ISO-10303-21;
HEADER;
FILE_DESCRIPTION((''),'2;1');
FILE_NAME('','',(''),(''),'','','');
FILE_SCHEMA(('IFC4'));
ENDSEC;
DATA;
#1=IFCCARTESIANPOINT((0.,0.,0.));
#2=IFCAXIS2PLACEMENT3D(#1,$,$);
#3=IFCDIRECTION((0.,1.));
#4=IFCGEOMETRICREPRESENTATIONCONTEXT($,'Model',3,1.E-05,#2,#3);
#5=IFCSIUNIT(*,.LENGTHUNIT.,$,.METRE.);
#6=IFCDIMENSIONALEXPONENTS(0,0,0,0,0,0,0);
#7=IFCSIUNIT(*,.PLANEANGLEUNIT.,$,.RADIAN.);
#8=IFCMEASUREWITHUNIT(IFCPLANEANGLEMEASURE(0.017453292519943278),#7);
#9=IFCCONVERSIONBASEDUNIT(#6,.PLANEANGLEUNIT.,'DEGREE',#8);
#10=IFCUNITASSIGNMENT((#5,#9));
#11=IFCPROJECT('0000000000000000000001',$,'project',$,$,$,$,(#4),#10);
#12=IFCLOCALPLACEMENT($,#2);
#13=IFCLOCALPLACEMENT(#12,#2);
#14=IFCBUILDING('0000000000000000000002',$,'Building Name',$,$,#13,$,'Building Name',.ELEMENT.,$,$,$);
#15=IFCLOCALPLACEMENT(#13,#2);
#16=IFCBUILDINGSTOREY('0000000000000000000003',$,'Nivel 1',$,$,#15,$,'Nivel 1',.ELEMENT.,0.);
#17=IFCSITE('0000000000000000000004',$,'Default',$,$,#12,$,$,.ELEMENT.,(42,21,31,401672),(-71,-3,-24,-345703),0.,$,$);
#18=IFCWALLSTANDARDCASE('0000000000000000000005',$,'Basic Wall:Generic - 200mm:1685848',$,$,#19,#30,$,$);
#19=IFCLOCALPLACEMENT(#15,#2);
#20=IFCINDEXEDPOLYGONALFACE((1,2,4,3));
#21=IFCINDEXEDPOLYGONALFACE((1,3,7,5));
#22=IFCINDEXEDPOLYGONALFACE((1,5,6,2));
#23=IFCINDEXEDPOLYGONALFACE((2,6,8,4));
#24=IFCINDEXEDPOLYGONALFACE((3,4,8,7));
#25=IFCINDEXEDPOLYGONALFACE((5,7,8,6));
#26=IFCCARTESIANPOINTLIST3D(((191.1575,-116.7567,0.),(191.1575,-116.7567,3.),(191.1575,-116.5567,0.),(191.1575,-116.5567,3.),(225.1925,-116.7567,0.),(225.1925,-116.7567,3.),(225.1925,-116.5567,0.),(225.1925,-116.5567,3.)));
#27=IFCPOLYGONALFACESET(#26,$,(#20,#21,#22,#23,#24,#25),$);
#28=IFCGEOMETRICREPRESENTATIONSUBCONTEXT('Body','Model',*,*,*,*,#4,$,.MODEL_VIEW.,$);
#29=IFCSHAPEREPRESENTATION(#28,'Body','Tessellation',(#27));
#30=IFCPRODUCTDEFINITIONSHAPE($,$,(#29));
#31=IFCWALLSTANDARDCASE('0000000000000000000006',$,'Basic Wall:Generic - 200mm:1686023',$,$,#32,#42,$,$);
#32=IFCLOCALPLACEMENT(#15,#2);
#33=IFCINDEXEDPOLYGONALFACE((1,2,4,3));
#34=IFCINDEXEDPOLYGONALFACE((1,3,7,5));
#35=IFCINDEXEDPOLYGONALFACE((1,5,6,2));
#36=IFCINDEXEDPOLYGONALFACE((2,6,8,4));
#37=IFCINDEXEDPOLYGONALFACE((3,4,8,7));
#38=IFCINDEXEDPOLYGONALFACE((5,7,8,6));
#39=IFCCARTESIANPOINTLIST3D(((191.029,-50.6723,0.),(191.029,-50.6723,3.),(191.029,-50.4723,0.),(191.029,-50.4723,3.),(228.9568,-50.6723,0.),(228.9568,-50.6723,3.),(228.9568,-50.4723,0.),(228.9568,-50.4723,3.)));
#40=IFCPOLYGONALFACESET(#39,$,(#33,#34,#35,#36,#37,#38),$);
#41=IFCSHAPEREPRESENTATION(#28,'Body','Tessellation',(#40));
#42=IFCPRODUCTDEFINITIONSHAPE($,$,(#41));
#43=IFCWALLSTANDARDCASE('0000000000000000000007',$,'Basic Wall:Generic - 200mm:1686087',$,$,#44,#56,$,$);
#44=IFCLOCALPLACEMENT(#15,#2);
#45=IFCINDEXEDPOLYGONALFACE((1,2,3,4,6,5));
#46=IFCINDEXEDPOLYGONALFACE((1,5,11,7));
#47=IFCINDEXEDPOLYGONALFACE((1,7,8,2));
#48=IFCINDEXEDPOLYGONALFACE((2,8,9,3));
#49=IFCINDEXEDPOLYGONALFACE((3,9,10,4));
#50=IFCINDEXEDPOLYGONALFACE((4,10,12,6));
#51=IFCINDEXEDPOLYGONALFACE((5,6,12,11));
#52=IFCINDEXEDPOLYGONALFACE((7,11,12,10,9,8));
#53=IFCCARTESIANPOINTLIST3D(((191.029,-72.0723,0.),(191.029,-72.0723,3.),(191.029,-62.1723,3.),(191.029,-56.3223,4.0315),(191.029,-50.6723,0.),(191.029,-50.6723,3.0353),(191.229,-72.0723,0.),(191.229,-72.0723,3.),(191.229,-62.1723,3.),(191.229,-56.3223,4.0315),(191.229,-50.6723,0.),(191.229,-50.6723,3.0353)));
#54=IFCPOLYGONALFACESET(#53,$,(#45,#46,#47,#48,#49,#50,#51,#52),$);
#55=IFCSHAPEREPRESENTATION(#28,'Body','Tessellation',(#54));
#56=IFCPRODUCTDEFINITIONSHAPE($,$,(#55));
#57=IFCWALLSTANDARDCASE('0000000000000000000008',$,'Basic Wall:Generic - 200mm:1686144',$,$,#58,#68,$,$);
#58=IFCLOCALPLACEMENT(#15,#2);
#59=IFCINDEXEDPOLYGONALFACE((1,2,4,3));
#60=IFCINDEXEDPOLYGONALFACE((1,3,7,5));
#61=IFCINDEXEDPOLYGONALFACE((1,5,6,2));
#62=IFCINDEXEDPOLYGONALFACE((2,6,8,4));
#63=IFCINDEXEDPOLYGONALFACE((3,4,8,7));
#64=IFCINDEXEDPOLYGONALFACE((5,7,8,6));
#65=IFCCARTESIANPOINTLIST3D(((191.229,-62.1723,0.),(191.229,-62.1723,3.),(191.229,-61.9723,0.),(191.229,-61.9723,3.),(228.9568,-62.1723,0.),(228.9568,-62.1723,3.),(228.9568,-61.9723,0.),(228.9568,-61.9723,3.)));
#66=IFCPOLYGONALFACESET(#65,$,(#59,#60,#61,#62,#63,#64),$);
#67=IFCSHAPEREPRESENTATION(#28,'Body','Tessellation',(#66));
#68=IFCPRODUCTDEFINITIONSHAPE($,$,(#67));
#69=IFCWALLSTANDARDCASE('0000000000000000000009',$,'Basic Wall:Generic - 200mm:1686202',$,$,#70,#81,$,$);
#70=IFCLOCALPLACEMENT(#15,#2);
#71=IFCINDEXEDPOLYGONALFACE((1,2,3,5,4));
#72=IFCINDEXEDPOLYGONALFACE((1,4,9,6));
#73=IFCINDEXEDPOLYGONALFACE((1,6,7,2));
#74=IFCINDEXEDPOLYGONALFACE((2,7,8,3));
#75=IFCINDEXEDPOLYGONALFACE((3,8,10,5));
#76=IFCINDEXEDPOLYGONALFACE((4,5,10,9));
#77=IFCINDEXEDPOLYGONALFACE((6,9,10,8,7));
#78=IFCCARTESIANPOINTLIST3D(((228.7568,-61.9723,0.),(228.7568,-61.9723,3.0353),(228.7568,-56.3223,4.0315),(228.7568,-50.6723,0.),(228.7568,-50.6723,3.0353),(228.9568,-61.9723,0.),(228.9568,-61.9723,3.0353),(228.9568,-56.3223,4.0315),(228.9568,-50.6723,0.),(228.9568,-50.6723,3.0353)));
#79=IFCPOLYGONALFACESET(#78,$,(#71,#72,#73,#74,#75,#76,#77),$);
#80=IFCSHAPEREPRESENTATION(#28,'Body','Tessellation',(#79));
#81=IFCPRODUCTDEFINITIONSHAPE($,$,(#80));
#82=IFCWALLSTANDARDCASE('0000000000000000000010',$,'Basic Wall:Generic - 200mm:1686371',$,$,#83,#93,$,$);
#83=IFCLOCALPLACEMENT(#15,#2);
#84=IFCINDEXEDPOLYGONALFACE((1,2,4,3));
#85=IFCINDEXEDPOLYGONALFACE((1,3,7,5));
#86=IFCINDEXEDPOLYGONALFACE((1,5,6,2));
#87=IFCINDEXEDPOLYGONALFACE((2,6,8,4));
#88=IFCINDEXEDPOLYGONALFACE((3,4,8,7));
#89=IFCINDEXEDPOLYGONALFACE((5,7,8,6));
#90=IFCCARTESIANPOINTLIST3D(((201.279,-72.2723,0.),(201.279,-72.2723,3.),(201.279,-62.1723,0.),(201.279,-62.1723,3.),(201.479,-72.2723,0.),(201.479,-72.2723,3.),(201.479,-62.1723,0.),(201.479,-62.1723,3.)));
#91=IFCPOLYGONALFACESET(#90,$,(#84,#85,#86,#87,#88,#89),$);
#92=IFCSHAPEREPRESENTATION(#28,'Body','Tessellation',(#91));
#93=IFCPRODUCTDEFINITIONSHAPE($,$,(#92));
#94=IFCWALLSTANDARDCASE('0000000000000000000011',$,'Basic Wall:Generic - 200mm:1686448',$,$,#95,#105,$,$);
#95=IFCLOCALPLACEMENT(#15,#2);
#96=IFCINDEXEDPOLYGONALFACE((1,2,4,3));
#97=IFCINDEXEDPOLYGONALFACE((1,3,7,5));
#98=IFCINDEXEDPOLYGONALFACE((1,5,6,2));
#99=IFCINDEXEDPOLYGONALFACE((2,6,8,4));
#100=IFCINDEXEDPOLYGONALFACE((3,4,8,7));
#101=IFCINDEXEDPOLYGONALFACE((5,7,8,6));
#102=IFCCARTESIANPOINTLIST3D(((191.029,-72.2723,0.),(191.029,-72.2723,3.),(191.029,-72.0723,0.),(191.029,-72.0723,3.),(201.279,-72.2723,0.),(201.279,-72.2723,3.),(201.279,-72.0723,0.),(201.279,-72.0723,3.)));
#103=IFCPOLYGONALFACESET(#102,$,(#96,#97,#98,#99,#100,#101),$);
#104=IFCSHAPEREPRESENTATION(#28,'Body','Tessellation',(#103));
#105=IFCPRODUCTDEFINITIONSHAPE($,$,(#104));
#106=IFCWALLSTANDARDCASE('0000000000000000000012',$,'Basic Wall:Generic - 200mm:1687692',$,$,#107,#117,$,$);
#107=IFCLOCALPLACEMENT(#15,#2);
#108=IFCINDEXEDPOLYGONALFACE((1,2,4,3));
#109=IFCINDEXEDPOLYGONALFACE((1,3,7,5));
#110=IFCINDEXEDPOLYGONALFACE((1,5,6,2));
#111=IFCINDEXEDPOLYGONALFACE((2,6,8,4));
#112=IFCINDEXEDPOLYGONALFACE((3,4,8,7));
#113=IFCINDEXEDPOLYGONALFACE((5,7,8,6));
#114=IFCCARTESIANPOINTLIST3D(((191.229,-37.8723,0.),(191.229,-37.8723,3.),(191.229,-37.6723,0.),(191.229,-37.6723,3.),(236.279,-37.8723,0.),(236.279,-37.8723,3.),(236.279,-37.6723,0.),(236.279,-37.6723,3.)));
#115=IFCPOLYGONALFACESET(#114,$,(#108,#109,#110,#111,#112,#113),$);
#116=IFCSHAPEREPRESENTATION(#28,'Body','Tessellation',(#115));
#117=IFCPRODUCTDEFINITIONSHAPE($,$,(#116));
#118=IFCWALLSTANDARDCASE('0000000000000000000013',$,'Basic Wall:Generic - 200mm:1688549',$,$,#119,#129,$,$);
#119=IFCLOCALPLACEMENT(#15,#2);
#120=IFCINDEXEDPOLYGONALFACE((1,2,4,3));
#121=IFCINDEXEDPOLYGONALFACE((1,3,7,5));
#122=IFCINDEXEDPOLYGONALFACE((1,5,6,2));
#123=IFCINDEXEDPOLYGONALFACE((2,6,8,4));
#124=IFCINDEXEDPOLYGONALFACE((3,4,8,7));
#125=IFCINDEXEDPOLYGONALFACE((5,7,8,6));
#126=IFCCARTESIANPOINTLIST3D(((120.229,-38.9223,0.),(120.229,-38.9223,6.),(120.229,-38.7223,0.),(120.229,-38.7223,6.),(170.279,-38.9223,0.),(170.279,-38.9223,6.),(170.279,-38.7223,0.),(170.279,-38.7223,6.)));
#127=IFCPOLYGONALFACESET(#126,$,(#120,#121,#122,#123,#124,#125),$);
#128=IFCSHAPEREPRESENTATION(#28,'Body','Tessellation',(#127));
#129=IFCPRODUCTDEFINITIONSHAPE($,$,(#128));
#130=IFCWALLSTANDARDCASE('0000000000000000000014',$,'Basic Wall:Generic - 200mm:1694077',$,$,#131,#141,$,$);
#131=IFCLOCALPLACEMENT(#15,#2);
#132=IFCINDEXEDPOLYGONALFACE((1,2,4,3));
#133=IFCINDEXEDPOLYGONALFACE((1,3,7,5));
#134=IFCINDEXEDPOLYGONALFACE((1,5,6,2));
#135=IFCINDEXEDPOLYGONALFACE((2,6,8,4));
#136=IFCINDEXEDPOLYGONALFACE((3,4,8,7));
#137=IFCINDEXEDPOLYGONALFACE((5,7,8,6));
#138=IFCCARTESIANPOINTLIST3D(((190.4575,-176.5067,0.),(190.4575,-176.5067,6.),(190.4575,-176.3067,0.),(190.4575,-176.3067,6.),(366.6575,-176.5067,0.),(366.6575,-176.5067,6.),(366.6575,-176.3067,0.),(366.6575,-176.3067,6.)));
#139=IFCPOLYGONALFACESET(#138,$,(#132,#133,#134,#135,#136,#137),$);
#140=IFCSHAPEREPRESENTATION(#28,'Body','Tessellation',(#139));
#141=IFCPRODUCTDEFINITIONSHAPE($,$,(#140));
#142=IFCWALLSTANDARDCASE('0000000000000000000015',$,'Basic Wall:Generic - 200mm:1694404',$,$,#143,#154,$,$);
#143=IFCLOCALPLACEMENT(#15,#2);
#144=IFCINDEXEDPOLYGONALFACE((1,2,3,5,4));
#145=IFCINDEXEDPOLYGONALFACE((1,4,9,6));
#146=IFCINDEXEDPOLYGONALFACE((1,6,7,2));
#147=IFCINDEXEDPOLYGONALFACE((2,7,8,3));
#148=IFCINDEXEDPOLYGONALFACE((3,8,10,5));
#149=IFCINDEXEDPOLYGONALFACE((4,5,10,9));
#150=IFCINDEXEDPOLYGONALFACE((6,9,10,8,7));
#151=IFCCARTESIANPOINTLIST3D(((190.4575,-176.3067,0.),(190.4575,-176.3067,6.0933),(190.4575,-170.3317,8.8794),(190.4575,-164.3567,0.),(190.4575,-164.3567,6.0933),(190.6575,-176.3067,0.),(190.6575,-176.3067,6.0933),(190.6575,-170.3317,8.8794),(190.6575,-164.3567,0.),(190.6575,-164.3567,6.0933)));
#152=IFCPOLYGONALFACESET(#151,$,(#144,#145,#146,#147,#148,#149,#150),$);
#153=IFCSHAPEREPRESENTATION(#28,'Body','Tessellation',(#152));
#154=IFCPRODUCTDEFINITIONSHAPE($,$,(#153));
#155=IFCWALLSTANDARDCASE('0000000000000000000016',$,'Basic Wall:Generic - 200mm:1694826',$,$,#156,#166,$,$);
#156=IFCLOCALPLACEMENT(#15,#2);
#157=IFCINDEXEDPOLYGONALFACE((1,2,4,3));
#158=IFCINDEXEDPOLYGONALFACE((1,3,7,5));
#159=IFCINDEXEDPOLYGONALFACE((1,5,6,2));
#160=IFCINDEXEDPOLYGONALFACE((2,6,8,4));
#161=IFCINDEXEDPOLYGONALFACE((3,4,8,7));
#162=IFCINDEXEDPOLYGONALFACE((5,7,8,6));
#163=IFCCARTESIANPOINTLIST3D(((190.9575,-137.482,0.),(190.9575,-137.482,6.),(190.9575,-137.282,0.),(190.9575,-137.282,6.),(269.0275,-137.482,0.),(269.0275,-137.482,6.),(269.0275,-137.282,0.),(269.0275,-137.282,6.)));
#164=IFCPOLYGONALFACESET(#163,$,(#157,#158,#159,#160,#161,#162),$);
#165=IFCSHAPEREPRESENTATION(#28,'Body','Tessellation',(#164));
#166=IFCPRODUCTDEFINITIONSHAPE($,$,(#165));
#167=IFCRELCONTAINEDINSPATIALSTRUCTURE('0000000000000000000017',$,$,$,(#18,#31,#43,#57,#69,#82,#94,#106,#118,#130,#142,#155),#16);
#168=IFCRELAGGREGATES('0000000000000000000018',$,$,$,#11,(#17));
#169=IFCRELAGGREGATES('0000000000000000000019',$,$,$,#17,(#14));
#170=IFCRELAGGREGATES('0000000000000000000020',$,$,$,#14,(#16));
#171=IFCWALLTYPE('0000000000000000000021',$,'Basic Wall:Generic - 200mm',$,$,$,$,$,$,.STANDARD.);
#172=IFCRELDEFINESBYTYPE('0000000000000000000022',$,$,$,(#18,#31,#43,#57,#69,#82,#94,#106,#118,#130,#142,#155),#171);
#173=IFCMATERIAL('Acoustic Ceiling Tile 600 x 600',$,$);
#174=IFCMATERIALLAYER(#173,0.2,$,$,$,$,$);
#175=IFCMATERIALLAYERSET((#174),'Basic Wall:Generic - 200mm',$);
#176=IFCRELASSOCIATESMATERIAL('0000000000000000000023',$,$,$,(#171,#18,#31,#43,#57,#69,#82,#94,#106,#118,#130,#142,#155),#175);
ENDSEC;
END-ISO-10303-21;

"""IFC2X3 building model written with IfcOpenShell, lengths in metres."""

from ifc_helpers import new_model, entity, si_unit, converted_unit, direction, frame, frame_2d, origin, place, context, subcontext, project, spatial, polyline, rectangle, extrude, clip, bounded_halfspace, material, layer, layer_set, layer_usage, type_object, element, save


model = new_model("IFC2X3")

# Units and contexts
model_context = context("Model", 3, precision=1e-05, world=origin(), true_north=direction((0.0, 1.0)))
body_context = subcontext(model_context, "Body", "Model", "MODEL_VIEW")
ifc_project = project(units=[si_unit("LENGTHUNIT", "METRE"), converted_unit("PLANEANGLEUNIT", "DEGREE", entity("IfcPlaneAngleMeasure", 0.017453292519943278), si_unit("PLANEANGLEUNIT", "RADIAN"), dimensions=[0, 0, 0, 0, 0, 0, 0])], contexts=[model_context])

# Site, building, storey
site_placement = place(None, origin())
site = spatial("IfcSite", under=ifc_project, at=site_placement, Name="Default", CompositionType="ELEMENT", RefLatitude=(42, 21, 31, 401672), RefLongitude=(-71, -3, -24, -345703), RefElevation=0.0)
building_placement = place(site_placement, origin())
building = spatial("IfcBuilding", under=site, at=building_placement, Name="Building Name", LongName="Building Name", CompositionType="ELEMENT")
storey_placement = place(building_placement, origin())
storey = spatial("IfcBuildingStorey", under=building, at=storey_placement, Name="Nivel 1", LongName="Nivel 1", CompositionType="ELEMENT", Elevation=0.0)

# Walls
ifc_material_1 = material(Name="Acoustic Ceiling Tile 600 x 600")
ifc_layer = layer(ifc_material_1, 0.2)
ifc_layer_set = layer_set([ifc_layer], Name="Basic Wall:Generic - 200mm")
wall_type_1 = type_object("IfcWallType", Name="Basic Wall:Generic - 200mm", PredefinedType="STANDARD", material=ifc_layer_set)
ifc_layer_usage_1 = layer_usage(ifc_layer_set, "AXIS2", "NEGATIVE", 0.1)
wall_1_placement = place(storey_placement, frame((191.1575, -116.6567, 0.0)))
element("IfcWallStandardCase", 1, at=wall_1_placement, inside=storey, type_object=wall_type_1, material=ifc_layer_usage_1, Name="Basic Wall:Generic - 200mm:1685848", context=body_context, shape_type="SweptSolid", body=[
    extrude(rectangle(XDim=34.035, YDim=0.2, at=frame_2d((17.0175, 0.0), x_axis=(-1.0, 0.0))), origin(), (0.0, 0.0, 1.0), 3.0),
])
ifc_layer_usage_2 = layer_usage(ifc_layer_set, "AXIS2", "NEGATIVE", 0.1)
wall_2_placement = place(storey_placement, frame((228.9568, -50.5723, 0.0), z_axis=(0.0, 0.0, 1.0), x_axis=(-1.0, 0.0, 0.0)))
element("IfcWallStandardCase", 2, at=wall_2_placement, inside=storey, type_object=wall_type_1, material=ifc_layer_usage_2, Name="Basic Wall:Generic - 200mm:1686023", context=body_context, shape_type="SweptSolid", body=[
    extrude(rectangle(XDim=37.9278, YDim=0.2, at=frame_2d((18.9639, 0.0), x_axis=(-1.0, 0.0))), origin(), (0.0, 0.0, 1.0), 3.0),
])
ifc_layer_usage_3 = layer_usage(ifc_layer_set, "AXIS2", "NEGATIVE", 0.1)
wall_3_placement = place(storey_placement, frame((191.129, -50.6723, 0.0), z_axis=(0.0, 0.0, 1.0), x_axis=(0.0, -1.0, 0.0)))
element("IfcWallStandardCase", 3, at=wall_3_placement, inside=storey, type_object=wall_type_1, material=ifc_layer_usage_3, Name="Basic Wall:Generic - 200mm:1686087", context=body_context, shape_type="Clipping", body=[
    clip(clip(clip(extrude(rectangle(XDim=21.4, YDim=0.2, at=frame_2d((10.7, 0.0), x_axis=(-1.0, 0.0))), origin(), (0.0, 0.0, 1.0), 4.0315), bounded_halfspace(frame((0.0, -0.1, 3.0353), z_axis=(-0.173648, 0.0, 0.984808), x_axis=(0.0, -1.0, 0.0)), False, frame((0.0, -0.1, 3.0353)), polyline([(0.0, 0.0), (5.65, 0.0), (5.65, 0.2), (0.0, 0.2), (0.0, 0.0)]))), bounded_halfspace(frame((5.65, -0.1, 4.0315), z_axis=(0.173648, 0.0, 0.984808), x_axis=(0.0, 1.0, 0.0)), False, frame((5.65, -0.1, 4.0315)), polyline([(0.0, 0.0), (5.85, 0.0), (5.85, 0.2), (0.0, 0.2), (0.0, 0.0)]))), bounded_halfspace(frame((11.5, -0.1, 3.0), z_axis=(0.0, 0.0, 1.0), x_axis=(0.0, 1.0, 0.0)), False, frame((11.5, -0.1, 3.0)), polyline([(0.0, 0.0), (9.9, 0.0), (9.9, 0.2), (0.0, 0.2), (0.0, 0.0)]))),
])
ifc_layer_usage_4 = layer_usage(ifc_layer_set, "AXIS2", "NEGATIVE", 0.1)
wall_4_placement = place(storey_placement, frame((191.229, -62.0723, 0.0)))
element("IfcWallStandardCase", 4, at=wall_4_placement, inside=storey, type_object=wall_type_1, material=ifc_layer_usage_4, Name="Basic Wall:Generic - 200mm:1686144", context=body_context, shape_type="SweptSolid", body=[
    extrude(rectangle(XDim=37.7278, YDim=0.2, at=frame_2d((18.8639, 0.0), x_axis=(-1.0, 0.0))), origin(), (0.0, 0.0, 1.0), 3.0),
])
ifc_layer_usage_5 = layer_usage(ifc_layer_set, "AXIS2", "NEGATIVE", 0.1)
wall_5_placement = place(storey_placement, frame((228.8568, -61.9723, 0.0), z_axis=(0.0, 0.0, 1.0), x_axis=(0.0, 1.0, 0.0)))
element("IfcWallStandardCase", 5, at=wall_5_placement, inside=storey, type_object=wall_type_1, material=ifc_layer_usage_5, Name="Basic Wall:Generic - 200mm:1686202", context=body_context, shape_type="Clipping", body=[
    clip(clip(extrude(rectangle(XDim=11.3, YDim=0.2, at=frame_2d((5.65, 0.0), x_axis=(-1.0, 0.0))), origin(), (0.0, 0.0, 1.0), 4.0315), bounded_halfspace(frame((5.65, -0.1, 4.0315), z_axis=(0.173648, 0.0, 0.984808), x_axis=(0.0, 1.0, 0.0)), False, frame((5.65, -0.1, 4.0315)), polyline([(0.0, 0.0), (5.65, 0.0), (5.65, 0.2), (0.0, 0.2), (0.0, 0.0)]))), bounded_halfspace(frame((0.0, -0.1, 3.0353), z_axis=(-0.173648, 0.0, 0.984808), x_axis=(0.0, -1.0, 0.0)), False, frame((0.0, -0.1, 3.0353)), polyline([(0.0, 0.0), (5.65, 0.0), (5.65, 0.2), (0.0, 0.2), (0.0, 0.0)]))),
])
ifc_layer_usage_6 = layer_usage(ifc_layer_set, "AXIS2", "NEGATIVE", 0.1)
wall_6_placement = place(storey_placement, frame((201.379, -62.1723, 0.0), z_axis=(0.0, 0.0, 1.0), x_axis=(0.0, -1.0, 0.0)))
element("IfcWallStandardCase", 6, at=wall_6_placement, inside=storey, type_object=wall_type_1, material=ifc_layer_usage_6, Name="Basic Wall:Generic - 200mm:1686371", context=body_context, shape_type="SweptSolid", body=[
    extrude(rectangle(XDim=10.1, YDim=0.2, at=frame_2d((5.05, 0.0), x_axis=(-1.0, 0.0))), origin(), (0.0, 0.0, 1.0), 3.0),
])
ifc_layer_usage_7 = layer_usage(ifc_layer_set, "AXIS2", "NEGATIVE", 0.1)
wall_7_placement = place(storey_placement, frame((201.279, -72.1723, 0.0), z_axis=(0.0, 0.0, 1.0), x_axis=(-1.0, 0.0, 0.0)))
element("IfcWallStandardCase", 7, at=wall_7_placement, inside=storey, type_object=wall_type_1, material=ifc_layer_usage_7, Name="Basic Wall:Generic - 200mm:1686448", context=body_context, shape_type="SweptSolid", body=[
    extrude(rectangle(XDim=10.25, YDim=0.2, at=frame_2d((5.125, 0.0), x_axis=(-1.0, 0.0))), origin(), (0.0, 0.0, 1.0), 3.0),
])
ifc_layer_usage_8 = layer_usage(ifc_layer_set, "AXIS2", "NEGATIVE", 0.1)
wall_8_placement = place(storey_placement, frame((191.229, -37.7723, 0.0)))
element("IfcWallStandardCase", 8, at=wall_8_placement, inside=storey, type_object=wall_type_1, material=ifc_layer_usage_8, Name="Basic Wall:Generic - 200mm:1687692", context=body_context, shape_type="SweptSolid", body=[
    extrude(rectangle(XDim=45.05, YDim=0.2, at=frame_2d((22.525, 0.0), x_axis=(-1.0, 0.0))), origin(), (0.0, 0.0, 1.0), 3.0),
])
ifc_layer_usage_9 = layer_usage(ifc_layer_set, "AXIS2", "NEGATIVE", 0.1)
wall_9_placement = place(storey_placement, frame((170.279, -38.8223, 0.0), z_axis=(0.0, 0.0, 1.0), x_axis=(-1.0, 0.0, 0.0)))
element("IfcWallStandardCase", 9, at=wall_9_placement, inside=storey, type_object=wall_type_1, material=ifc_layer_usage_9, Name="Basic Wall:Generic - 200mm:1688549", context=body_context, shape_type="SweptSolid", body=[
    extrude(rectangle(XDim=50.05, YDim=0.2, at=frame_2d((25.025, 0.0), x_axis=(-1.0, 0.0))), origin(), (0.0, 0.0, 1.0), 6.0),
])
ifc_layer_usage_10 = layer_usage(ifc_layer_set, "AXIS2", "NEGATIVE", 0.1)
wall_10_placement = place(storey_placement, frame((190.4575, -176.4067, 0.0)))
element("IfcWallStandardCase", 10, at=wall_10_placement, inside=storey, type_object=wall_type_1, material=ifc_layer_usage_10, Name="Basic Wall:Generic - 200mm:1694077", context=body_context, shape_type="SweptSolid", body=[
    extrude(rectangle(XDim=176.2, YDim=0.2, at=frame_2d((88.1, 0.0), x_axis=(-1.0, 0.0))), origin(), (0.0, 0.0, 1.0), 6.0),
])
ifc_layer_usage_11 = layer_usage(ifc_layer_set, "AXIS2", "NEGATIVE", 0.1)
wall_11_placement = place(storey_placement, frame((190.5575, -164.3567, 0.0), z_axis=(0.0, 0.0, 1.0), x_axis=(0.0, -1.0, 0.0)))
element("IfcWallStandardCase", 11, at=wall_11_placement, inside=storey, type_object=wall_type_1, material=ifc_layer_usage_11, Name="Basic Wall:Generic - 200mm:1694404", context=body_context, shape_type="Clipping", body=[
    clip(clip(extrude(rectangle(XDim=11.95, YDim=0.2, at=frame_2d((5.975, 0.0), x_axis=(-1.0, 0.0))), origin(), (0.0, 0.0, 1.0), 8.8794), bounded_halfspace(frame((0.0, -0.1, 6.0933), z_axis=(-0.422618, 0.0, 0.906308), x_axis=(0.0, -1.0, 0.0)), False, frame((0.0, -0.1, 6.0933)), polyline([(0.0, 0.0), (5.975, 0.0), (5.975, 0.2), (0.0, 0.2), (0.0, 0.0)]))), bounded_halfspace(frame((5.975, -0.1, 8.8794), z_axis=(0.422618, 0.0, 0.906308), x_axis=(0.0, 1.0, 0.0)), False, frame((5.975, -0.1, 8.8794)), polyline([(0.0, 0.0), (5.975, 0.0), (5.975, 0.2), (0.0, 0.2), (0.0, 0.0)]))),
])
ifc_layer_usage_12 = layer_usage(ifc_layer_set, "AXIS2", "NEGATIVE", 0.1)
wall_12_placement = place(storey_placement, frame((190.9575, -137.382, 0.0)))
element("IfcWallStandardCase", 12, at=wall_12_placement, inside=storey, type_object=wall_type_1, material=ifc_layer_usage_12, Name="Basic Wall:Generic - 200mm:1694826", context=body_context, shape_type="SweptSolid", body=[
    extrude(rectangle(XDim=78.07, YDim=0.2, at=frame_2d((39.035, 0.0), x_axis=(-1.0, 0.0))), origin(), (0.0, 0.0, 1.0), 6.0),
])

save(model, "model.ifc")
